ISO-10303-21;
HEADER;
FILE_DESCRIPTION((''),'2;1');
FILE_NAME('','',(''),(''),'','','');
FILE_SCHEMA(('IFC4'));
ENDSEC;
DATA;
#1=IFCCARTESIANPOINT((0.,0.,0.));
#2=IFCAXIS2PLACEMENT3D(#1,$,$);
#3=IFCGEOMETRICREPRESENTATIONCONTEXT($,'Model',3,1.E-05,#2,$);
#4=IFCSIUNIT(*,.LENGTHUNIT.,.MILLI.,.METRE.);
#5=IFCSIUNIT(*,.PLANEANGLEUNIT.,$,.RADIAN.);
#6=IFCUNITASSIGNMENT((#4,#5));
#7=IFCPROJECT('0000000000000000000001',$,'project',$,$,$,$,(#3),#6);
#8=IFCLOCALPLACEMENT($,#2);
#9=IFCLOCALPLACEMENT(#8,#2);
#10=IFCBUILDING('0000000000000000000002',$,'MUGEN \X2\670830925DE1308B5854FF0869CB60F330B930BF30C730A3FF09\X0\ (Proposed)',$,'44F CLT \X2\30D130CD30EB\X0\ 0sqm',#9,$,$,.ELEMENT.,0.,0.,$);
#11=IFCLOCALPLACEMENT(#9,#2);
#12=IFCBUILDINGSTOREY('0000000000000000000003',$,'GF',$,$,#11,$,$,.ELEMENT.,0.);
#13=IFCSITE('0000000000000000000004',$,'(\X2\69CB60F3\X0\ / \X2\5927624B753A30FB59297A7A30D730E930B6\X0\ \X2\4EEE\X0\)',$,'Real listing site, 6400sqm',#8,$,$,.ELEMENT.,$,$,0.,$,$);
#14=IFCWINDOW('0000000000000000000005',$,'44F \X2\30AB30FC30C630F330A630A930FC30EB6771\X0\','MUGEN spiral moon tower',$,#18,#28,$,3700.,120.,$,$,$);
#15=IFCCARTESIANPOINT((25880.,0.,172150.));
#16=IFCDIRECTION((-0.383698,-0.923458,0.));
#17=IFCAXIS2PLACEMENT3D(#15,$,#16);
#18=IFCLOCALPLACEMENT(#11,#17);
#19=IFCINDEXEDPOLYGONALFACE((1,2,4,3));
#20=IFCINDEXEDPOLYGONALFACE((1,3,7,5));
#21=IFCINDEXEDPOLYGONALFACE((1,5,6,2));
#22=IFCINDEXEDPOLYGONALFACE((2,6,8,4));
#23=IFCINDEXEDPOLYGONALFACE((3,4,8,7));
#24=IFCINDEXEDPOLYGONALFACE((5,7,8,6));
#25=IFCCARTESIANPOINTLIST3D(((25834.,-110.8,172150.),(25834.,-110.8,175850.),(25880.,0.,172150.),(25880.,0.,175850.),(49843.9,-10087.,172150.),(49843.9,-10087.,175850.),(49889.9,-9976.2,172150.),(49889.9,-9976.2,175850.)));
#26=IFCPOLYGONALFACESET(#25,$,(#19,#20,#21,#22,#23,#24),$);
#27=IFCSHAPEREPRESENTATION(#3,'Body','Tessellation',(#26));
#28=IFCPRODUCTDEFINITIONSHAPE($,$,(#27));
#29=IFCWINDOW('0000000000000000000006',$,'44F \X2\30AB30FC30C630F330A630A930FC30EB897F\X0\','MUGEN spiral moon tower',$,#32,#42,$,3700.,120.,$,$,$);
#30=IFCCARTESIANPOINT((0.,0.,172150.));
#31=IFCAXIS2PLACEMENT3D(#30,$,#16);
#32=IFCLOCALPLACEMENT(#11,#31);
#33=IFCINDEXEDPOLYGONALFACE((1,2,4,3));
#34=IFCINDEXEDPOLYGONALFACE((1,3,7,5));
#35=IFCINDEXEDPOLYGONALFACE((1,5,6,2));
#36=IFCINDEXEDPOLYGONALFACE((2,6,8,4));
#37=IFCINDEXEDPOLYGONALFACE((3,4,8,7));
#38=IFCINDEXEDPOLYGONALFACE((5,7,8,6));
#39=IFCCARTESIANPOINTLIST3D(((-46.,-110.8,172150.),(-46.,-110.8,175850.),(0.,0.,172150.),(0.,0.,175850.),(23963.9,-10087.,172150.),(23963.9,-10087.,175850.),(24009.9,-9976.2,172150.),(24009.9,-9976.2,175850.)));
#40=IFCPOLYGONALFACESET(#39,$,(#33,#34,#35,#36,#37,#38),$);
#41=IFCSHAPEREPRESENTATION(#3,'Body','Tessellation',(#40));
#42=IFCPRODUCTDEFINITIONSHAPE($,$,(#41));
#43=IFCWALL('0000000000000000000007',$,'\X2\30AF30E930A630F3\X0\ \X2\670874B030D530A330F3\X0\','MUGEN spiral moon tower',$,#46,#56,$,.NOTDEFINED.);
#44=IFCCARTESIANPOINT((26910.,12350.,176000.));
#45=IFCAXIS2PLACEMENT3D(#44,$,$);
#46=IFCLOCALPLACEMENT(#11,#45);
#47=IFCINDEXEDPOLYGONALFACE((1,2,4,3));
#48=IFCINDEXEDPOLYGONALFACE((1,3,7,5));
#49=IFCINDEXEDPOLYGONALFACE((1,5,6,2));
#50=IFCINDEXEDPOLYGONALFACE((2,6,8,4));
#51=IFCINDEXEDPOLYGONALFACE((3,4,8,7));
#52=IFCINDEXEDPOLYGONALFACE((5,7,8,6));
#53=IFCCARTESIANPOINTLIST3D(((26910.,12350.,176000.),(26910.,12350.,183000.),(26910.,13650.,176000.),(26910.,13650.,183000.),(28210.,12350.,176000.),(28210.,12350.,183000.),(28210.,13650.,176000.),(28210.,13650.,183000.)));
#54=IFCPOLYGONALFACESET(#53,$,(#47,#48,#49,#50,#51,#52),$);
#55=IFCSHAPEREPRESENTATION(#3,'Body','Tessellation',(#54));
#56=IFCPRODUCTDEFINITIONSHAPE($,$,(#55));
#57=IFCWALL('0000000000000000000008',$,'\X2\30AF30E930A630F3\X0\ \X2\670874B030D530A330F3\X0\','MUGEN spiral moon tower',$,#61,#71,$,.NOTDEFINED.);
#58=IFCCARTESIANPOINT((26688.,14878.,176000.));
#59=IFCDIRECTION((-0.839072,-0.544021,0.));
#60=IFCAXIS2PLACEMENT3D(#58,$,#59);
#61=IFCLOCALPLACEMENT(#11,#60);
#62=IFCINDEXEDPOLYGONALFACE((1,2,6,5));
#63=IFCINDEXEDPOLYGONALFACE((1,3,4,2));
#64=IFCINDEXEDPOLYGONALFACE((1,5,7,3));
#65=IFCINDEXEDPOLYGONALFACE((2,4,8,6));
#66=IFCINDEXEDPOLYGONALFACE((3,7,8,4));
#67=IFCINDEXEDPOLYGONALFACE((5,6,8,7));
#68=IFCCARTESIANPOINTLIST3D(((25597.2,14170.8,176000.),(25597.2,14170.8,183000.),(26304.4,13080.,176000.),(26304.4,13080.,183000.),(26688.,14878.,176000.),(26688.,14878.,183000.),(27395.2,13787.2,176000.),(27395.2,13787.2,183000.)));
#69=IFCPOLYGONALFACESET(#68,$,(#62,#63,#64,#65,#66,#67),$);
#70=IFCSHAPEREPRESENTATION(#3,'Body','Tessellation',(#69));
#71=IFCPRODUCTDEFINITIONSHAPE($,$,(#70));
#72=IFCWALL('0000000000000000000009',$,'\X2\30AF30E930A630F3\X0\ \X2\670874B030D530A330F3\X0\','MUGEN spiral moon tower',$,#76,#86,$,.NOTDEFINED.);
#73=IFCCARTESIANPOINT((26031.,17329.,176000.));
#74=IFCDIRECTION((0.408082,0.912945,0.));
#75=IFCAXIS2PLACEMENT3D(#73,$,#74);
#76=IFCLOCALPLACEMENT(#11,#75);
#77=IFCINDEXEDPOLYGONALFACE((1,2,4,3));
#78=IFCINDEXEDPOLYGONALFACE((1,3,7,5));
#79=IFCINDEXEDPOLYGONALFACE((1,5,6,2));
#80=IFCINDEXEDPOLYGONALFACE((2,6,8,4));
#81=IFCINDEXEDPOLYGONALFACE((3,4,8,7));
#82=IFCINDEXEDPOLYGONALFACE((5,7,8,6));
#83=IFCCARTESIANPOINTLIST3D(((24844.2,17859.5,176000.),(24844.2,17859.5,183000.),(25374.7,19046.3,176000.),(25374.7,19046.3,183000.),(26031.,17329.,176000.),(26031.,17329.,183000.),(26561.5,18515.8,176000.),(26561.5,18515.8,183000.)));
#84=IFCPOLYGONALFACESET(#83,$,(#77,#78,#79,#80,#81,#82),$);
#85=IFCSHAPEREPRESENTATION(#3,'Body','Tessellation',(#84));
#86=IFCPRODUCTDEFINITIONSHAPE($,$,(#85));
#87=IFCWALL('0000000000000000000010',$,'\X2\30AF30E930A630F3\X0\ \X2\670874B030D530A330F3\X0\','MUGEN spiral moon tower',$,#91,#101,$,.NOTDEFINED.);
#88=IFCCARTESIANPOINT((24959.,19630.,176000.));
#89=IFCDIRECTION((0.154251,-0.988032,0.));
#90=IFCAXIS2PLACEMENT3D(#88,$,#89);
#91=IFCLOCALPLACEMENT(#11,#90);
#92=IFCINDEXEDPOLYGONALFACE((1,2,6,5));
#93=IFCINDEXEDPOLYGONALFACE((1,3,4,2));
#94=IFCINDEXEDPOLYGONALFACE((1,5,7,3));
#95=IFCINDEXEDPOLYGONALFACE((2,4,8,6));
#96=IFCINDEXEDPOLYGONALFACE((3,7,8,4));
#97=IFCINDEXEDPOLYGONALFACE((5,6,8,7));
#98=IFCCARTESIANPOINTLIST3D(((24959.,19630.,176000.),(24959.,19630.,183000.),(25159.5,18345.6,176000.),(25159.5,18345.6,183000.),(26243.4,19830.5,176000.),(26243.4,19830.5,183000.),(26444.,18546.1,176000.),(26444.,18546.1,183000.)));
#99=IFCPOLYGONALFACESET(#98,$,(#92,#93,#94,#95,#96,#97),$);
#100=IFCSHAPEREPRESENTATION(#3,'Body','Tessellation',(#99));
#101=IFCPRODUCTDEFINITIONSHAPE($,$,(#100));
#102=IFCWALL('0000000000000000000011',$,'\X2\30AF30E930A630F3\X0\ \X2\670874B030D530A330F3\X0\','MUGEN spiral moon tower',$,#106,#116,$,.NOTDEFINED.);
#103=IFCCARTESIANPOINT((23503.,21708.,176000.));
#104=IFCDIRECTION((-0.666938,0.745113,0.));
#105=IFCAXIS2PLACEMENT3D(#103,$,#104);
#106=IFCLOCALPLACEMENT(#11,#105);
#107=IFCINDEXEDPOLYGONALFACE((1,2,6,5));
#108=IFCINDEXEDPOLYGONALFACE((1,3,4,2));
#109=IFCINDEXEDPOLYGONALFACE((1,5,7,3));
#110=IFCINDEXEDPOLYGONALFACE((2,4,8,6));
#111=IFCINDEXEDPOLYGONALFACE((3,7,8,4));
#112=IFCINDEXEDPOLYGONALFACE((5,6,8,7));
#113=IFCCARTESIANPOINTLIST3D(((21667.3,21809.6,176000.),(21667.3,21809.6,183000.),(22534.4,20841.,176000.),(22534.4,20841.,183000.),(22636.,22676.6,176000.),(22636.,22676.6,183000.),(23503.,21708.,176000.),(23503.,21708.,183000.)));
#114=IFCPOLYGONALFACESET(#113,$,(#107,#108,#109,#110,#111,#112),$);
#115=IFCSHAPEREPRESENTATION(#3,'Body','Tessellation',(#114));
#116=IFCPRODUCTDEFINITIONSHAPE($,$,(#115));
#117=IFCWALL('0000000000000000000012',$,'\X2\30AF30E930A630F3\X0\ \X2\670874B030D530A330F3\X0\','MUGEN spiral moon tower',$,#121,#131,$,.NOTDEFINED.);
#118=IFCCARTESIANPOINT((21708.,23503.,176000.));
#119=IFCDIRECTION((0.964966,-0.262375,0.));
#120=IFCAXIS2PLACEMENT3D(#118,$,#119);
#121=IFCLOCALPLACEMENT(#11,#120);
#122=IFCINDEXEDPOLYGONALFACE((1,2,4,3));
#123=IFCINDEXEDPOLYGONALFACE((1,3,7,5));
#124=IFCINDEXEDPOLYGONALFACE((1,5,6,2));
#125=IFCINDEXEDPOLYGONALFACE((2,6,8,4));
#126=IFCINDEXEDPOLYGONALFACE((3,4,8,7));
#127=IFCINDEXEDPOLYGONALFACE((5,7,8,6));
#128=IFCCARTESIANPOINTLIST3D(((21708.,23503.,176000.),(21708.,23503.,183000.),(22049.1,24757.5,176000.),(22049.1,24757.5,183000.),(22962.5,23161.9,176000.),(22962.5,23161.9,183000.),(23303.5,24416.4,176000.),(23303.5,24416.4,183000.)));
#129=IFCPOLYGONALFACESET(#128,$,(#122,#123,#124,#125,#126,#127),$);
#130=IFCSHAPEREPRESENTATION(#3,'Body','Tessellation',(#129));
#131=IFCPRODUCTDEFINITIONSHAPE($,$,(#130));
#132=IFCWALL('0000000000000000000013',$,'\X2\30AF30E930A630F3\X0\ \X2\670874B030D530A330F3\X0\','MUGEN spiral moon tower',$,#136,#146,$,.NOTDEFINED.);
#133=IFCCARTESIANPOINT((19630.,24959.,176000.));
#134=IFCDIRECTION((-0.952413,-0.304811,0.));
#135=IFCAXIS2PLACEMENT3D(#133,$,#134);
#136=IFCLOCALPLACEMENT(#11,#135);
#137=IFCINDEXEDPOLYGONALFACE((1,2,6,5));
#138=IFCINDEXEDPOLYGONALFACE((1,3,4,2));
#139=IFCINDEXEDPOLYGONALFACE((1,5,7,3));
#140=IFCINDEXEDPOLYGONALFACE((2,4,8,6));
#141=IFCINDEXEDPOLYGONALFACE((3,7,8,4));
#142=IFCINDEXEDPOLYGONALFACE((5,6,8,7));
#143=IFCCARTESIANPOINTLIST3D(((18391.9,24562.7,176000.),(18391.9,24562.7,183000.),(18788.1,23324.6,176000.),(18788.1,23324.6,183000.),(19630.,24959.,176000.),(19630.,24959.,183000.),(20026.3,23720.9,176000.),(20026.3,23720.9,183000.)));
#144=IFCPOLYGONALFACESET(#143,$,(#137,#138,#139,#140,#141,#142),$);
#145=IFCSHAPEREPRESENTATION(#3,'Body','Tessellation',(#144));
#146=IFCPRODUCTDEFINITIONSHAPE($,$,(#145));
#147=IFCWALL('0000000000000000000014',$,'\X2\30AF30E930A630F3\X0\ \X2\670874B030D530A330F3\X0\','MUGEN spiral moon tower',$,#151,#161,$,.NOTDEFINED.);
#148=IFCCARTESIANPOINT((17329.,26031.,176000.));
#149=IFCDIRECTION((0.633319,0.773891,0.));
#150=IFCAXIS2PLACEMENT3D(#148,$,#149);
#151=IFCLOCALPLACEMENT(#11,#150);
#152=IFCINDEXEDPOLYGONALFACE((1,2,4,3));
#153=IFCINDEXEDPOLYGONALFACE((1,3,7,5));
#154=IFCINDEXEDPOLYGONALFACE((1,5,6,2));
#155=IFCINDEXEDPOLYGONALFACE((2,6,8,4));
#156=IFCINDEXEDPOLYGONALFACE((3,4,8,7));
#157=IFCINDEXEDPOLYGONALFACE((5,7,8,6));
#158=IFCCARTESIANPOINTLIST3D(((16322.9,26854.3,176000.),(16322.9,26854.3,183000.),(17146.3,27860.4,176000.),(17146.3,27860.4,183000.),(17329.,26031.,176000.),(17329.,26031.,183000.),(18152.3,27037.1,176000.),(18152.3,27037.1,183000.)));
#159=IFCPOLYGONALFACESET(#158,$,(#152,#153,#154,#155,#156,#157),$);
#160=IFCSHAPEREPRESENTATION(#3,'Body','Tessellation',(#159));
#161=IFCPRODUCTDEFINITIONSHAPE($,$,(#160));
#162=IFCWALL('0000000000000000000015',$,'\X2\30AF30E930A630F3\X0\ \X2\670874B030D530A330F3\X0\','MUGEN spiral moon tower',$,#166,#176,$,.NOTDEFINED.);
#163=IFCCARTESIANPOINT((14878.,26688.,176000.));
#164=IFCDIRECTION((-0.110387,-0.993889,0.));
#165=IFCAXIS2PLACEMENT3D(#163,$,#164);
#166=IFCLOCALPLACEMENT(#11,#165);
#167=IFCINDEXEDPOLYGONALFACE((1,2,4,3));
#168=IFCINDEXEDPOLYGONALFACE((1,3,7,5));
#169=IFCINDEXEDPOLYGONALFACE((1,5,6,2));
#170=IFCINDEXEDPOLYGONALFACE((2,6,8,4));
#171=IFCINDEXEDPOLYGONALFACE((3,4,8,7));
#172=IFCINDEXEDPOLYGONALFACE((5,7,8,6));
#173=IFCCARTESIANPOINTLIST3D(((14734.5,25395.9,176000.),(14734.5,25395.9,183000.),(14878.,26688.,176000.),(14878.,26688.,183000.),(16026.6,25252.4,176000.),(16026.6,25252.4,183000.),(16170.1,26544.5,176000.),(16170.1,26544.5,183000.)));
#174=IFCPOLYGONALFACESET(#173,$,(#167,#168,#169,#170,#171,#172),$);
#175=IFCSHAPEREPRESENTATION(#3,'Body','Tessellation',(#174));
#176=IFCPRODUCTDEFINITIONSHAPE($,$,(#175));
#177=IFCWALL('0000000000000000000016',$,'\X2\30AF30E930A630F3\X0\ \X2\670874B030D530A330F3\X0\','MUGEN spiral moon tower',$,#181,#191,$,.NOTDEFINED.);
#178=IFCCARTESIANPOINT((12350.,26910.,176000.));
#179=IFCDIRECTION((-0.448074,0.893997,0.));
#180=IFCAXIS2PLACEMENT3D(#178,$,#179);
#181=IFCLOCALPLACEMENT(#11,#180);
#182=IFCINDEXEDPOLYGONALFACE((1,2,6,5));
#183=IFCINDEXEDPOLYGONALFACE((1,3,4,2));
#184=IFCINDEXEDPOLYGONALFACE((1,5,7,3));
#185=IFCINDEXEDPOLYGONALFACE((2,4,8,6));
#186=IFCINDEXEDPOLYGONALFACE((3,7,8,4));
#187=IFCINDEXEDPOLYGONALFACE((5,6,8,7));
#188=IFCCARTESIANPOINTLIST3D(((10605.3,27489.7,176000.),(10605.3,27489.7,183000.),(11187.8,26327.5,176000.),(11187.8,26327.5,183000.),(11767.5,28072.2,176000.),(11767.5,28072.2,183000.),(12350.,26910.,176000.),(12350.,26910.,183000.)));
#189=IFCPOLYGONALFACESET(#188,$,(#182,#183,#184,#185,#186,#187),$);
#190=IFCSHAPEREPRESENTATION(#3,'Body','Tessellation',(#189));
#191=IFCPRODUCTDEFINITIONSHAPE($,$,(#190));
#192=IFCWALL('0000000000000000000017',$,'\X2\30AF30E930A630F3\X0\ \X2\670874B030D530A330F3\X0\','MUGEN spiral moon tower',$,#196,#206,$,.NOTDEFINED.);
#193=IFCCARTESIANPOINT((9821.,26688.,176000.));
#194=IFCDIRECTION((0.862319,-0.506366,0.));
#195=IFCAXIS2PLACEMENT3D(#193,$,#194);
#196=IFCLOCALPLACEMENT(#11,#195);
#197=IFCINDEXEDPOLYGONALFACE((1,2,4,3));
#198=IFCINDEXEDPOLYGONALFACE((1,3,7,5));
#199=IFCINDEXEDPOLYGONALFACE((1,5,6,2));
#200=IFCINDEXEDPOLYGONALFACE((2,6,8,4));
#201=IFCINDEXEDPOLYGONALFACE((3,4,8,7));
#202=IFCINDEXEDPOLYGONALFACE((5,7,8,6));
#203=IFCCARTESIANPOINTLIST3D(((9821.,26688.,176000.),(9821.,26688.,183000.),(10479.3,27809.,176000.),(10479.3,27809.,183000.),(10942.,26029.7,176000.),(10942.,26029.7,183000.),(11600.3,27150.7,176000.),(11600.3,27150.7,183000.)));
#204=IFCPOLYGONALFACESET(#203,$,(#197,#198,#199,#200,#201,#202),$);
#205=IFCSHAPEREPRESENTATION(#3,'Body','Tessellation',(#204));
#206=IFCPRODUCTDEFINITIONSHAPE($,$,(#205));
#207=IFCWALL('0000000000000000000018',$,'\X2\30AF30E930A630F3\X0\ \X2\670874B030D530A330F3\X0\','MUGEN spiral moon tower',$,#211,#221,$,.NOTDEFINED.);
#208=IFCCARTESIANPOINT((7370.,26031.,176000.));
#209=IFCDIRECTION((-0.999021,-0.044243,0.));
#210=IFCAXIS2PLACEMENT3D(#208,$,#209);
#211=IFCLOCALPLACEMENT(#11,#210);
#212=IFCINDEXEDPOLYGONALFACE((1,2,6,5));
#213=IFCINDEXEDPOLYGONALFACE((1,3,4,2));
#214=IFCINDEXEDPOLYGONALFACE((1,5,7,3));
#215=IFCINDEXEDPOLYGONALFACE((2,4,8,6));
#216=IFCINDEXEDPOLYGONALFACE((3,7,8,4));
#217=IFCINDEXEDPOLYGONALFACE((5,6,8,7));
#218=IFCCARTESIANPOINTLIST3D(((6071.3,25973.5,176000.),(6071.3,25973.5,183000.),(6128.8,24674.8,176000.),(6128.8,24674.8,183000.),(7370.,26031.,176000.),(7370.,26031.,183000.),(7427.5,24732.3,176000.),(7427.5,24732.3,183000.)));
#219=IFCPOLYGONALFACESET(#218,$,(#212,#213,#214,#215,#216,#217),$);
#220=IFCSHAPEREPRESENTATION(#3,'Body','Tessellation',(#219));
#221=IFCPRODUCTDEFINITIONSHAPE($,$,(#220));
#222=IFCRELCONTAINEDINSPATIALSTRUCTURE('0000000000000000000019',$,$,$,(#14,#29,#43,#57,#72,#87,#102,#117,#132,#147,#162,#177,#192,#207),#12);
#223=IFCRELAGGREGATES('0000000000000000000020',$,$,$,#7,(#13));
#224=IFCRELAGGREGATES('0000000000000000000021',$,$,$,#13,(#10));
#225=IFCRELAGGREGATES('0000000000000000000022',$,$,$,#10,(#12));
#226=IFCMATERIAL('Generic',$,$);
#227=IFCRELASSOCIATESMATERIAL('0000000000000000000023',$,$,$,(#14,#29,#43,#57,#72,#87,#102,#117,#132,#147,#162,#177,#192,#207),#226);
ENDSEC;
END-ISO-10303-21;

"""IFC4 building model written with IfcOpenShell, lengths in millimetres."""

from ifc_helpers import new_model, si_unit, frame, frame_2d, origin, place, context, project, spatial, rectangle, extrude, material, element, save


model = new_model("IFC4")

# Units and contexts
model_context = context("Model", 3, precision=1e-05, world=origin())
ifc_project = project(units=[si_unit("LENGTHUNIT", "METRE", prefix="MILLI"), si_unit("PLANEANGLEUNIT", "RADIAN")], contexts=[model_context])

# Site, building, storey
site_placement = place(None, origin())
site = spatial("IfcSite", under=ifc_project, at=site_placement, Name="(構想 / 大手町・天空プラザ 仮)", ObjectType="Real listing site, 6400sqm", CompositionType="ELEMENT", RefElevation=0.0)
building_placement = place(site_placement, origin())
building = spatial("IfcBuilding", under=site, at=building_placement, Name="MUGEN 月を巡る塔（構想スタディ） (Proposed)", ObjectType="44F CLT パネル 0sqm", CompositionType="ELEMENT", ElevationOfRefHeight=0.0, ElevationOfTerrain=0.0)
storey_placement = place(building_placement, origin())
storey = spatial("IfcBuildingStorey", under=building, at=storey_placement, Name="GF", CompositionType="ELEMENT", Elevation=0.0)

# Windows
ifc_material = material(Name="Generic")
window_1_placement = place(storey_placement, frame((25880.0, 0.0, 172150.0), x_axis=(-0.383698, -0.923458, 0.0)))
element("IfcWindow", 1, at=window_1_placement, inside=storey, material=ifc_material, Name="44F カーテンウォール東", Description="MUGEN spiral moon tower", OverallHeight=3700.0, OverallWidth=120.0, context=model_context, shape_type="SweptSolid", body=[
    extrude(rectangle(XDim=120.0, YDim=26000.0, at=frame_2d((60.0, 13000.0))), frame((25880.0, 0.0, 172150.0), x_axis=(-0.383698, -0.923458, 0.0)), (0.0, 0.0, 1.0), 3700.0),
])
window_2_placement = place(storey_placement, frame((0.0, 0.0, 172150.0), x_axis=(-0.383698, -0.923458, 0.0)))
element("IfcWindow", 2, at=window_2_placement, inside=storey, material=ifc_material, Name="44F カーテンウォール西", Description="MUGEN spiral moon tower", OverallHeight=3700.0, OverallWidth=120.0, context=model_context, shape_type="SweptSolid", body=[
    extrude(rectangle(XDim=120.0, YDim=26000.0, at=frame_2d((60.0, 13000.0))), frame((0.0, 0.0, 172150.0), x_axis=(-0.383698, -0.923458, 0.0)), (0.0, 0.0, 1.0), 3700.0),
])

# Walls
wall_1_placement = place(storey_placement, frame((26910.0, 12350.0, 176000.0)))
element("IfcWall", 3, at=wall_1_placement, inside=storey, material=ifc_material, Name="クラウン 月環フィン", Description="MUGEN spiral moon tower", PredefinedType="NOTDEFINED", context=model_context, shape_type="SweptSolid", body=[
    extrude(rectangle(XDim=1300.0, YDim=1300.0, at=frame_2d((650.0, 650.0))), frame((26910.0, 12350.0, 176000.0)), (0.0, 0.0, 1.0), 7000.0),
])
wall_2_placement = place(storey_placement, frame((26688.0, 14878.0, 176000.0), x_axis=(-0.839072, -0.544021, 0.0)))
element("IfcWall", 4, at=wall_2_placement, inside=storey, material=ifc_material, Name="クラウン 月環フィン", Description="MUGEN spiral moon tower", PredefinedType="NOTDEFINED", context=model_context, shape_type="SweptSolid", body=[
    extrude(rectangle(XDim=1300.0, YDim=1300.0, at=frame_2d((650.0, 650.0))), frame((26688.0, 14878.0, 176000.0), x_axis=(-0.839072, -0.544021, 0.0)), (0.0, 0.0, 1.0), 7000.0),
])
wall_3_placement = place(storey_placement, frame((26031.0, 17329.0, 176000.0), x_axis=(0.408082, 0.912945, 0.0)))
element("IfcWall", 5, at=wall_3_placement, inside=storey, material=ifc_material, Name="クラウン 月環フィン", Description="MUGEN spiral moon tower", PredefinedType="NOTDEFINED", context=model_context, shape_type="SweptSolid", body=[
    extrude(rectangle(XDim=1300.0, YDim=1300.0, at=frame_2d((650.0, 650.0))), frame((26031.0, 17329.0, 176000.0), x_axis=(0.408082, 0.912945, 0.0)), (0.0, 0.0, 1.0), 7000.0),
])
wall_4_placement = place(storey_placement, frame((24959.0, 19630.0, 176000.0), x_axis=(0.154251, -0.988032, 0.0)))
element("IfcWall", 6, at=wall_4_placement, inside=storey, material=ifc_material, Name="クラウン 月環フィン", Description="MUGEN spiral moon tower", PredefinedType="NOTDEFINED", context=model_context, shape_type="SweptSolid", body=[
    extrude(rectangle(XDim=1300.0, YDim=1300.0, at=frame_2d((650.0, 650.0))), frame((24959.0, 19630.0, 176000.0), x_axis=(0.154251, -0.988032, 0.0)), (0.0, 0.0, 1.0), 7000.0),
])
wall_5_placement = place(storey_placement, frame((23503.0, 21708.0, 176000.0), x_axis=(-0.666938, 0.745113, 0.0)))
element("IfcWall", 7, at=wall_5_placement, inside=storey, material=ifc_material, Name="クラウン 月環フィン", Description="MUGEN spiral moon tower", PredefinedType="NOTDEFINED", context=model_context, shape_type="SweptSolid", body=[
    extrude(rectangle(XDim=1300.0, YDim=1300.0, at=frame_2d((650.0, 650.0))), frame((23503.0, 21708.0, 176000.0), x_axis=(-0.666938, 0.745113, 0.0)), (0.0, 0.0, 1.0), 7000.0),
])
wall_6_placement = place(storey_placement, frame((21708.0, 23503.0, 176000.0), x_axis=(0.964966, -0.262375, 0.0)))
element("IfcWall", 8, at=wall_6_placement, inside=storey, material=ifc_material, Name="クラウン 月環フィン", Description="MUGEN spiral moon tower", PredefinedType="NOTDEFINED", context=model_context, shape_type="SweptSolid", body=[
    extrude(rectangle(XDim=1300.0, YDim=1300.0, at=frame_2d((650.0, 650.0))), frame((21708.0, 23503.0, 176000.0), x_axis=(0.964966, -0.262375, 0.0)), (0.0, 0.0, 1.0), 7000.0),
])
wall_7_placement = place(storey_placement, frame((19630.0, 24959.0, 176000.0), x_axis=(-0.952413, -0.304811, 0.0)))
element("IfcWall", 9, at=wall_7_placement, inside=storey, material=ifc_material, Name="クラウン 月環フィン", Description="MUGEN spiral moon tower", PredefinedType="NOTDEFINED", context=model_context, shape_type="SweptSolid", body=[
    extrude(rectangle(XDim=1300.0, YDim=1300.0, at=frame_2d((650.0, 650.0))), frame((19630.0, 24959.0, 176000.0), x_axis=(-0.952413, -0.304811, 0.0)), (0.0, 0.0, 1.0), 7000.0),
])
wall_8_placement = place(storey_placement, frame((17329.0, 26031.0, 176000.0), x_axis=(0.633319, 0.773891, 0.0)))
element("IfcWall", 10, at=wall_8_placement, inside=storey, material=ifc_material, Name="クラウン 月環フィン", Description="MUGEN spiral moon tower", PredefinedType="NOTDEFINED", context=model_context, shape_type="SweptSolid", body=[
    extrude(rectangle(XDim=1300.0, YDim=1300.0, at=frame_2d((650.0, 650.0))), frame((17329.0, 26031.0, 176000.0), x_axis=(0.633319, 0.773891, 0.0)), (0.0, 0.0, 1.0), 7000.0),
])
wall_9_placement = place(storey_placement, frame((14878.0, 26688.0, 176000.0), x_axis=(-0.110387, -0.993889, 0.0)))
element("IfcWall", 11, at=wall_9_placement, inside=storey, material=ifc_material, Name="クラウン 月環フィン", Description="MUGEN spiral moon tower", PredefinedType="NOTDEFINED", context=model_context, shape_type="SweptSolid", body=[
    extrude(rectangle(XDim=1300.0, YDim=1300.0, at=frame_2d((650.0, 650.0))), frame((14878.0, 26688.0, 176000.0), x_axis=(-0.110387, -0.993889, 0.0)), (0.0, 0.0, 1.0), 7000.0),
])
wall_10_placement = place(storey_placement, frame((12350.0, 26910.0, 176000.0), x_axis=(-0.448074, 0.893997, 0.0)))
element("IfcWall", 12, at=wall_10_placement, inside=storey, material=ifc_material, Name="クラウン 月環フィン", Description="MUGEN spiral moon tower", PredefinedType="NOTDEFINED", context=model_context, shape_type="SweptSolid", body=[
    extrude(rectangle(XDim=1300.0, YDim=1300.0, at=frame_2d((650.0, 650.0))), frame((12350.0, 26910.0, 176000.0), x_axis=(-0.448074, 0.893997, 0.0)), (0.0, 0.0, 1.0), 7000.0),
])
wall_11_placement = place(storey_placement, frame((9821.0, 26688.0, 176000.0), x_axis=(0.862319, -0.506366, 0.0)))
element("IfcWall", 13, at=wall_11_placement, inside=storey, material=ifc_material, Name="クラウン 月環フィン", Description="MUGEN spiral moon tower", PredefinedType="NOTDEFINED", context=model_context, shape_type="SweptSolid", body=[
    extrude(rectangle(XDim=1300.0, YDim=1300.0, at=frame_2d((650.0, 650.0))), frame((9821.0, 26688.0, 176000.0), x_axis=(0.862319, -0.506366, 0.0)), (0.0, 0.0, 1.0), 7000.0),
])
wall_12_placement = place(storey_placement, frame((7370.0, 26031.0, 176000.0), x_axis=(-0.999021, -0.044243, 0.0)))
element("IfcWall", 14, at=wall_12_placement, inside=storey, material=ifc_material, Name="クラウン 月環フィン", Description="MUGEN spiral moon tower", PredefinedType="NOTDEFINED", context=model_context, shape_type="SweptSolid", body=[
    extrude(rectangle(XDim=1300.0, YDim=1300.0, at=frame_2d((650.0, 650.0))), frame((7370.0, 26031.0, 176000.0), x_axis=(-0.999021, -0.044243, 0.0)), (0.0, 0.0, 1.0), 7000.0),
])

save(model, "model.ifc")
